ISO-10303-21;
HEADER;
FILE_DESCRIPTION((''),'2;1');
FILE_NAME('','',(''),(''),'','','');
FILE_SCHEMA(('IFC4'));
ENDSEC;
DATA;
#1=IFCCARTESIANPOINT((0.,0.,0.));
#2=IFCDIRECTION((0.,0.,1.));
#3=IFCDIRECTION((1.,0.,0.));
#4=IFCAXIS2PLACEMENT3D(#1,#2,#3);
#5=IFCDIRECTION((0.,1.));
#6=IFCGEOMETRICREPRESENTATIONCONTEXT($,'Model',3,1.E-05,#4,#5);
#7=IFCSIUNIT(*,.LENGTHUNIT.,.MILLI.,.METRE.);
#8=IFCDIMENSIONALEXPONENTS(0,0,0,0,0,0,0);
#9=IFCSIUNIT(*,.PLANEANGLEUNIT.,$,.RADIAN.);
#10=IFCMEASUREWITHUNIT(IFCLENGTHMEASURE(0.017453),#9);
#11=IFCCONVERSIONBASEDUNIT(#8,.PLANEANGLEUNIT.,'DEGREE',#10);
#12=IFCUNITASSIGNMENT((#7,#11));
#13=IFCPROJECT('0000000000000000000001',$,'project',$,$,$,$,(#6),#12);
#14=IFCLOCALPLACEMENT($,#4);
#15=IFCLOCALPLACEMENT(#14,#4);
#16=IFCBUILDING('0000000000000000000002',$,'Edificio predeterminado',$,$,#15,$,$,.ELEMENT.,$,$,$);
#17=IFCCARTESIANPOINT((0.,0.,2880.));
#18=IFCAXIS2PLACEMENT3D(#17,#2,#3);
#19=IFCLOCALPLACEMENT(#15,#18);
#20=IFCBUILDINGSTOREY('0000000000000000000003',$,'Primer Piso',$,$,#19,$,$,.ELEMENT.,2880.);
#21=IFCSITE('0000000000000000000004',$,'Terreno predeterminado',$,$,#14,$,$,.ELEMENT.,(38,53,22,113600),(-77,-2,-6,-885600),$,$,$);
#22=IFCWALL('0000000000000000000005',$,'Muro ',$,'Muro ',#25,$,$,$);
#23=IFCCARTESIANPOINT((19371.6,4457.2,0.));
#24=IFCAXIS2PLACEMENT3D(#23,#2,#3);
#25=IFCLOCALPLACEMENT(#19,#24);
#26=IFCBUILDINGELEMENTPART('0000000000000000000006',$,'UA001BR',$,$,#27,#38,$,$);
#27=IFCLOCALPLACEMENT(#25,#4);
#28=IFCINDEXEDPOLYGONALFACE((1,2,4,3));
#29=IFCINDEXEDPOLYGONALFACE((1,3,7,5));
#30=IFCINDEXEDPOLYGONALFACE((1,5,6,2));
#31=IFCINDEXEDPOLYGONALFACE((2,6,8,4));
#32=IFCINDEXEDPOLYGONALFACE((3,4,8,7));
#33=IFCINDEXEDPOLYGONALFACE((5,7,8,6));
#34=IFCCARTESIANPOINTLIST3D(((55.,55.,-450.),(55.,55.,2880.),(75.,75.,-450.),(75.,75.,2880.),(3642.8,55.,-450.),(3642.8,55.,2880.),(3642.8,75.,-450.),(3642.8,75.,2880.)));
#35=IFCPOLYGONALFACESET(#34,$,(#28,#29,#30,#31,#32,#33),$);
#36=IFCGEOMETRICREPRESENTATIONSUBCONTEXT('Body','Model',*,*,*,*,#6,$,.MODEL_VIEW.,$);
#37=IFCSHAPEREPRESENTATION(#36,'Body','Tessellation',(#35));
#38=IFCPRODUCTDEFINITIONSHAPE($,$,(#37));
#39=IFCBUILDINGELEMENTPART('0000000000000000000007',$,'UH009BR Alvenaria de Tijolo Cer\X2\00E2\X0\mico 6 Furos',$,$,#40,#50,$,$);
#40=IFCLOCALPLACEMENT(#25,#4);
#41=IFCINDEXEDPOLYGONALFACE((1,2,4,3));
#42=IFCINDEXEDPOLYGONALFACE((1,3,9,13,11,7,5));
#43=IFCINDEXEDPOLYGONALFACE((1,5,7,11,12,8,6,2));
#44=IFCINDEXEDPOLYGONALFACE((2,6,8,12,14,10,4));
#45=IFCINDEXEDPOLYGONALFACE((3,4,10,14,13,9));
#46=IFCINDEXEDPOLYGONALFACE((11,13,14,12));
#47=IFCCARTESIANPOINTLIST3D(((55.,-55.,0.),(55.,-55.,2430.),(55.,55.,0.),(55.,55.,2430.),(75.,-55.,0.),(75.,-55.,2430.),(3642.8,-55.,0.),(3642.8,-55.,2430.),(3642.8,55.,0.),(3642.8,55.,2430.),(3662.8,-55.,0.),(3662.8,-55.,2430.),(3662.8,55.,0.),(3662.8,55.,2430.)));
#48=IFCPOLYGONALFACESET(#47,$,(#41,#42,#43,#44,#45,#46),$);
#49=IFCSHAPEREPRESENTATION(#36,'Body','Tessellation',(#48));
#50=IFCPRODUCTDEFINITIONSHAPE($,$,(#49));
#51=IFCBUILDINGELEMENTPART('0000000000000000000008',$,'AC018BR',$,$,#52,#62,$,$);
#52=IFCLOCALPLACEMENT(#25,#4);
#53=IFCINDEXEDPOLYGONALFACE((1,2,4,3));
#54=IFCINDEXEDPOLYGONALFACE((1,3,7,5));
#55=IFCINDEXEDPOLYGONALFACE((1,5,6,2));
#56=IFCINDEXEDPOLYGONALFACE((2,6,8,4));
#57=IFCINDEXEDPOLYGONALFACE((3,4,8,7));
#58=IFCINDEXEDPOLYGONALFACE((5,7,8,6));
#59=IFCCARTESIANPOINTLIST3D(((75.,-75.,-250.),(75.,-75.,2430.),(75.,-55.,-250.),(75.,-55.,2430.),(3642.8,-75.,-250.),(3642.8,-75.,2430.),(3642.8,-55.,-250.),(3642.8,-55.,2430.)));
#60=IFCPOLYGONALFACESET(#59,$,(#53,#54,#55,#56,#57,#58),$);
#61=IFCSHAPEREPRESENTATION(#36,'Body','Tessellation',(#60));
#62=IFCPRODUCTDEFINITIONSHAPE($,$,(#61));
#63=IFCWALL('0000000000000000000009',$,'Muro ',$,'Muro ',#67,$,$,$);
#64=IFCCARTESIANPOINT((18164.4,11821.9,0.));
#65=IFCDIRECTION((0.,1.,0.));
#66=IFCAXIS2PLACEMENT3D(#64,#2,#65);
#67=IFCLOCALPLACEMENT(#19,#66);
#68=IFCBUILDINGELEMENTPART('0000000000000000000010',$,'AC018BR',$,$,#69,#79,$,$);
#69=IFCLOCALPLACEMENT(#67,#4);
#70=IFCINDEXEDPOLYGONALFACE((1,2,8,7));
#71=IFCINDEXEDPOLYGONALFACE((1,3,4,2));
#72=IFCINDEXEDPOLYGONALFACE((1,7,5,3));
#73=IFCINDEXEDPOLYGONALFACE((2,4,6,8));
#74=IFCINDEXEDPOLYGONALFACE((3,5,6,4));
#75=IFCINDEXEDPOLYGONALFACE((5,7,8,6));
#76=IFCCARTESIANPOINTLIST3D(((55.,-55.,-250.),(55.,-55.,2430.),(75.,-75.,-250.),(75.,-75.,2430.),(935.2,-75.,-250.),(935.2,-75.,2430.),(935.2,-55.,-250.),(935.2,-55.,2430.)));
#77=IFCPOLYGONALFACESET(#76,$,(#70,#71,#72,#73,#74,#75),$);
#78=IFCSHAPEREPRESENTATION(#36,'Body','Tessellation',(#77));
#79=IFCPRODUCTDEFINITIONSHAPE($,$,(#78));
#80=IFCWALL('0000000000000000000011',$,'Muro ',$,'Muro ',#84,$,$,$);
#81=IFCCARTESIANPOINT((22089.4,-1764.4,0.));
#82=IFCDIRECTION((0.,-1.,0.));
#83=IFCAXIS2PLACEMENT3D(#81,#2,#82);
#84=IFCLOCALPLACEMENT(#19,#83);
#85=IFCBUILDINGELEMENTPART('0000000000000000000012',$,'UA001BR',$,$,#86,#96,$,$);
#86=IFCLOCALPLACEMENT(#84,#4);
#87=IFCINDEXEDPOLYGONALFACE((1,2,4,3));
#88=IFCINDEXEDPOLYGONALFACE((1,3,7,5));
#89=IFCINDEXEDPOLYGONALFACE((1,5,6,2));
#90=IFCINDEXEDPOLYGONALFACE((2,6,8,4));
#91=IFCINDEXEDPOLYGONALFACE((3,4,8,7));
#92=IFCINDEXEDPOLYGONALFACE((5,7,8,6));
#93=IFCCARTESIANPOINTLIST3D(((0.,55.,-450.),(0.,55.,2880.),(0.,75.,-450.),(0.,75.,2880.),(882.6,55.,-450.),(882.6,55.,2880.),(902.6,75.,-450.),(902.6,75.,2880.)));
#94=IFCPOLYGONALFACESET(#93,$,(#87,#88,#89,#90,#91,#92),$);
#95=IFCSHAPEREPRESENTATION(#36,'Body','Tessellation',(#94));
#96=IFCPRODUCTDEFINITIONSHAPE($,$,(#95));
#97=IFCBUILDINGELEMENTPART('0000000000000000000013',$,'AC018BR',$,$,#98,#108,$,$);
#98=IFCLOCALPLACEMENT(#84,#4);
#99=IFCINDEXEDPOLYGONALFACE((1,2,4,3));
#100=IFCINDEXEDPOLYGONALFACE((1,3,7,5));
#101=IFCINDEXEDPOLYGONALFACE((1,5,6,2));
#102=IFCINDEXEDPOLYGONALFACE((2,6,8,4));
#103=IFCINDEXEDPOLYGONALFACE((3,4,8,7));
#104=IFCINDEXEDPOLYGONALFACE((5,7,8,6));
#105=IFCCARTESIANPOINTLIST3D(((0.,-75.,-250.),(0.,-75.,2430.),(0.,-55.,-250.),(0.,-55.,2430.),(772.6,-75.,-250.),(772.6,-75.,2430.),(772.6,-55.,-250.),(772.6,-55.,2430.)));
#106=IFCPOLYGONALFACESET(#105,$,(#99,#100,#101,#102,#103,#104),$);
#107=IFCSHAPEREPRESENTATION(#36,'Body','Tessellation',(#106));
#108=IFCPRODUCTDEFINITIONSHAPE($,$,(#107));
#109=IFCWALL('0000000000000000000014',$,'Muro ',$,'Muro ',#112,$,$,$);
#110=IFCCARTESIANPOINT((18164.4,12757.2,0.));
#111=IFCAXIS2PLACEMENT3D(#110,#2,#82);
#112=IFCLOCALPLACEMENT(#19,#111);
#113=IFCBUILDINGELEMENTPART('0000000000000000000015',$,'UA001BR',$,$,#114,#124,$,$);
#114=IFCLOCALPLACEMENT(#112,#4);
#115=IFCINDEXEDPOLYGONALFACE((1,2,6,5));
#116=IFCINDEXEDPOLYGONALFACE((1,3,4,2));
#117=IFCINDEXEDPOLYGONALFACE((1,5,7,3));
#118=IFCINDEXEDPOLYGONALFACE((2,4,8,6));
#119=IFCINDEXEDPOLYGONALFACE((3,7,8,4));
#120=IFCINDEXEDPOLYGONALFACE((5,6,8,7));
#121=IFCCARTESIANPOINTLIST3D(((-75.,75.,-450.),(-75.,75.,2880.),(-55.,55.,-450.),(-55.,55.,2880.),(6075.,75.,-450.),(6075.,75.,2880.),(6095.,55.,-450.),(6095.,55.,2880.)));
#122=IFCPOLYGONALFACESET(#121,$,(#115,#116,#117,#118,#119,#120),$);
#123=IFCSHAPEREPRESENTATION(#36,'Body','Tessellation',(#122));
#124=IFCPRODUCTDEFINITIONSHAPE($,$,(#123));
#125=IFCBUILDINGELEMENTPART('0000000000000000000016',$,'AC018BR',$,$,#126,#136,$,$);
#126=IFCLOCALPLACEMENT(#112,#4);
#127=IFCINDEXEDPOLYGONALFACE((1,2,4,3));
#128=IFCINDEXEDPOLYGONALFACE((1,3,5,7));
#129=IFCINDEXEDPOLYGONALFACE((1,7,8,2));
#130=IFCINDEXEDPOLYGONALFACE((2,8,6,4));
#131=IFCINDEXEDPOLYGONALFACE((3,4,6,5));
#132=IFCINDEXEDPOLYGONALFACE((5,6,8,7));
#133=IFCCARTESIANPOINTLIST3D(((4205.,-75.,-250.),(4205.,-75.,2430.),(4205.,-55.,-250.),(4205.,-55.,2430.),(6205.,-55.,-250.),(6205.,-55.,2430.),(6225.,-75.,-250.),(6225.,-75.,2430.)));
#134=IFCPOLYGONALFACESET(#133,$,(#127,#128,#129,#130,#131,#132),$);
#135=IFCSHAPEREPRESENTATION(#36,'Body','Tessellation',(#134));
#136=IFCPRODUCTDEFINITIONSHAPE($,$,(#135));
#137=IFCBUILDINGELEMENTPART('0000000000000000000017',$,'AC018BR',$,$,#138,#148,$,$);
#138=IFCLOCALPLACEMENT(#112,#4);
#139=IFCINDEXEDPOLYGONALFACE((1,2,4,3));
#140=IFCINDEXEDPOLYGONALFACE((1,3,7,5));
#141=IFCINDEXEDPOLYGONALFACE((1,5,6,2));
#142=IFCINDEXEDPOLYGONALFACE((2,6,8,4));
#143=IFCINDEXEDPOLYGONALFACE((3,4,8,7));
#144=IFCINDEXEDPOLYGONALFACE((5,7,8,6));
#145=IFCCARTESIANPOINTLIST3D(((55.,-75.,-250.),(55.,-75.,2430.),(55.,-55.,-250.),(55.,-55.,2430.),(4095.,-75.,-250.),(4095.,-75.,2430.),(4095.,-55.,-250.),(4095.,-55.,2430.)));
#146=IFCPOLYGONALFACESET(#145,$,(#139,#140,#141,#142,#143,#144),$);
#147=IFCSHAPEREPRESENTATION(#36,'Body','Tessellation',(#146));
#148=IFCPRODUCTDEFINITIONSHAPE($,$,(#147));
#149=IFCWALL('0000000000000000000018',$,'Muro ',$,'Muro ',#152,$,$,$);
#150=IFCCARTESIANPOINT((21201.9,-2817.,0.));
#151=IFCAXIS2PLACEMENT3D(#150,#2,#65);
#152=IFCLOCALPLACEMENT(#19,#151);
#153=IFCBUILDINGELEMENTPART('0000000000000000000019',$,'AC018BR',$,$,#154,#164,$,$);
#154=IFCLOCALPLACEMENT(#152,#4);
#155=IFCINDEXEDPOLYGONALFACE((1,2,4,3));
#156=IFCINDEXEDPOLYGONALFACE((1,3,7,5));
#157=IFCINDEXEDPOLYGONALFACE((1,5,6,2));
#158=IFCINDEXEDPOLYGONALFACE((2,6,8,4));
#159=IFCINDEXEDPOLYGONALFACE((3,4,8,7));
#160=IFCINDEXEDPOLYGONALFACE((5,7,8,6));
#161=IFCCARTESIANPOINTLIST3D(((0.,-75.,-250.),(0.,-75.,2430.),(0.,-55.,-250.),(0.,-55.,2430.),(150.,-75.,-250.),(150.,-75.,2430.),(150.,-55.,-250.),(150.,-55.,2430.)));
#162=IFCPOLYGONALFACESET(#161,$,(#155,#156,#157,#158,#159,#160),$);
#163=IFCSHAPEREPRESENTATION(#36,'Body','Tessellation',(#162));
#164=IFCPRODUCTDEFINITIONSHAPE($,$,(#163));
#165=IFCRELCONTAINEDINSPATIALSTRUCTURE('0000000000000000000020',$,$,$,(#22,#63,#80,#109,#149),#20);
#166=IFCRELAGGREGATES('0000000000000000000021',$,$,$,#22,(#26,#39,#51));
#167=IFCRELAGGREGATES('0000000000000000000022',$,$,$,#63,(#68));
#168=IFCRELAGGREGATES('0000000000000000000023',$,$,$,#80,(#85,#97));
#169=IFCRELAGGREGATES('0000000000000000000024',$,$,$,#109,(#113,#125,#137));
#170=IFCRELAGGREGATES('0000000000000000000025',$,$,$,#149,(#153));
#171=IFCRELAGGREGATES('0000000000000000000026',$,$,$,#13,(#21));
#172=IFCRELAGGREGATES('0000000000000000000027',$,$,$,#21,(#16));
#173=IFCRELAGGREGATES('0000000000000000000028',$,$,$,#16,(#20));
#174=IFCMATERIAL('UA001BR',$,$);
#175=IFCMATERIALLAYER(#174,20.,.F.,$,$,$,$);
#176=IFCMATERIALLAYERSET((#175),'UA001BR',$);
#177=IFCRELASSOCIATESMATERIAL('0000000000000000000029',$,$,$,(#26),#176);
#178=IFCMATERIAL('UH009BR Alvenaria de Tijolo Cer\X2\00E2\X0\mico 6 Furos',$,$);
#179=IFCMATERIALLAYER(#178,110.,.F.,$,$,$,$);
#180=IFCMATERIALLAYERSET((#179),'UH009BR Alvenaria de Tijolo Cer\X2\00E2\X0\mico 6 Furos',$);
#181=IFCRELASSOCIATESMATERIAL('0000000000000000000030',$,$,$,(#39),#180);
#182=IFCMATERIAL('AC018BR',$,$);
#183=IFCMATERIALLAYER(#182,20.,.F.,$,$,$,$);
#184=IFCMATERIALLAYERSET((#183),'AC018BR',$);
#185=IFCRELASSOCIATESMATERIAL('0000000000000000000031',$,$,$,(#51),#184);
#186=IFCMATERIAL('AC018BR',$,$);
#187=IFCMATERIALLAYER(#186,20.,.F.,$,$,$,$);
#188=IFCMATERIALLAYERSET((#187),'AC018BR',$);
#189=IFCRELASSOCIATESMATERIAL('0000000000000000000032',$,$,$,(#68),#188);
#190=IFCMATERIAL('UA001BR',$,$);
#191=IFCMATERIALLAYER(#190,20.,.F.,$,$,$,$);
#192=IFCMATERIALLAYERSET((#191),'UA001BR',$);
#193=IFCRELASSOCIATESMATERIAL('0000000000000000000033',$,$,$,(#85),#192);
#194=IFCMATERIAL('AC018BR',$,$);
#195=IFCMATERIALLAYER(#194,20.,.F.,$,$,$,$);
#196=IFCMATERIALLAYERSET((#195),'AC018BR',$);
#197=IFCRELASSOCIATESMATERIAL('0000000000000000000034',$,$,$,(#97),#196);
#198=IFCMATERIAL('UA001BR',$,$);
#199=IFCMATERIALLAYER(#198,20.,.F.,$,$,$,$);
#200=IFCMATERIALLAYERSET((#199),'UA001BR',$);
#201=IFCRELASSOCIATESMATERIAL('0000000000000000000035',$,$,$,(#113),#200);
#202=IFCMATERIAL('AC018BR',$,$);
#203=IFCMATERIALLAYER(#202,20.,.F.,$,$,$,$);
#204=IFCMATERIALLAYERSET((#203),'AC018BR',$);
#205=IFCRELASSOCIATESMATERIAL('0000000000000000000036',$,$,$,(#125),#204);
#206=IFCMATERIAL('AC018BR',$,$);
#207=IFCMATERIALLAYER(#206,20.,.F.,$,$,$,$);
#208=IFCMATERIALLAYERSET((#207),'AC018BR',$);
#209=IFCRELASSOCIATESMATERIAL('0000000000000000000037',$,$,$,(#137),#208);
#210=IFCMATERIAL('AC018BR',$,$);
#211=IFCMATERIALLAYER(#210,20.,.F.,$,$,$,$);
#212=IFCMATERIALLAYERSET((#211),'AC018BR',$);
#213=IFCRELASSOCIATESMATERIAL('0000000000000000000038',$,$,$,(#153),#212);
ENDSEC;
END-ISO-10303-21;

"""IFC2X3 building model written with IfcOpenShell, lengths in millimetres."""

from ifc_helpers import new_model, entity, si_unit, converted_unit, direction, frame, origin_with_axes, place, context, subcontext, project, spatial, polyline, outline, extrude, clip, bounded_halfspace, material, layer, layer_set, layer_usage, element, aggregate, save


model = new_model("IFC2X3")

# Units and contexts
model_context = context("Model", 3, precision=1e-05, world=origin_with_axes(), true_north=direction((0.0, 1.0)))
body_context = subcontext(model_context, "Body", "Model", "MODEL_VIEW")
ifc_project = project(units=[si_unit("LENGTHUNIT", "METRE", prefix="MILLI"), converted_unit("PLANEANGLEUNIT", "DEGREE", entity("IfcLengthMeasure", 0.017453), si_unit("PLANEANGLEUNIT", "RADIAN"), dimensions=[0, 0, 0, 0, 0, 0, 0])], contexts=[model_context])

# Site, building, storey
site_placement = place(None, origin_with_axes())
site = spatial("IfcSite", under=ifc_project, at=site_placement, Name="Terreno predeterminado", CompositionType="ELEMENT", RefLatitude=(38, 53, 22, 113600), RefLongitude=(-77, -2, -6, -885600))
building_placement = place(site_placement, origin_with_axes())
building = spatial("IfcBuilding", under=site, at=building_placement, Name="Edificio predeterminado", CompositionType="ELEMENT")
storey_placement = place(building_placement, frame((0.0, 0.0, 2880.0), z_axis=(0.0, 0.0, 1.0), x_axis=(1.0, 0.0, 0.0)))
storey = spatial("IfcBuildingStorey", under=building, at=storey_placement, Name="Primer Piso", CompositionType="ELEMENT", Elevation=2880.0)

# Walls, building element parts
wall_1_placement = place(storey_placement, frame((19371.6, 4457.2, 0.0), z_axis=(0.0, 0.0, 1.0), x_axis=(1.0, 0.0, 0.0)))
wall_1 = element("IfcWall", 1, at=wall_1_placement, inside=storey, Name="Muro ", ObjectType="Muro ")
ifc_material_1 = material(Name="UA001BR")
ifc_layer_1 = layer(ifc_material_1, 20.0, ventilated=False)
ifc_layer_set_1 = layer_set([ifc_layer_1], Name="UA001BR")
ifc_layer_usage_1 = layer_usage(ifc_layer_set_1, "AXIS2", "NEGATIVE", -75.0)
building_element_part_1_placement = place(wall_1_placement, origin_with_axes())
building_element_part_1 = element("IfcBuildingElementPart", 2, at=building_element_part_1_placement, material=ifc_layer_usage_1, Name="UA001BR", context=body_context, shape_type="SweptSolid", body=[
    extrude(outline(polyline([(3642.8, 75.0), (3642.8, 55.0), (55.0, 55.0), (75.0, 75.0), (3642.8, 75.0)])), frame((0.0, 0.0, -450.0), z_axis=(0.0, 0.0, 1.0), x_axis=(1.0, 0.0, 0.0)), (0.0, 0.0, 1.0), 3330.0),
])
ifc_material_2 = material(Name="UH009BR Alvenaria de Tijolo Cerâmico 6 Furos")
ifc_layer_2 = layer(ifc_material_2, 110.0, ventilated=False)
ifc_layer_set_2 = layer_set([ifc_layer_2], Name="UH009BR Alvenaria de Tijolo Cerâmico 6 Furos")
ifc_layer_usage_2 = layer_usage(ifc_layer_set_2, "AXIS2", "NEGATIVE", -55.0)
building_element_part_2_placement = place(wall_1_placement, origin_with_axes())
building_element_part_2 = element("IfcBuildingElementPart", 3, at=building_element_part_2_placement, material=ifc_layer_usage_2, Name="UH009BR Alvenaria de Tijolo Cerâmico 6 Furos", context=body_context, shape_type="SweptSolid", body=[
    extrude(outline(polyline([(3662.8, 55.0), (3662.8, -55.0), (3642.8, -55.0), (75.0, -55.0), (55.0, -55.0), (55.0, 55.0), (3642.8, 55.0), (3662.8, 55.0)])), origin_with_axes(), (0.0, 0.0, 1.0), 2430.0),
])
ifc_material_3 = material(Name="AC018BR")
ifc_layer_3 = layer(ifc_material_3, 20.0, ventilated=False)
ifc_layer_set_3 = layer_set([ifc_layer_3], Name="AC018BR")
ifc_layer_usage_3 = layer_usage(ifc_layer_set_3, "AXIS2", "NEGATIVE", 55.0)
building_element_part_3_placement = place(wall_1_placement, origin_with_axes())
building_element_part_3 = element("IfcBuildingElementPart", 4, at=building_element_part_3_placement, material=ifc_layer_usage_3, Name="AC018BR", context=body_context, shape_type="SweptSolid", body=[
    extrude(outline(polyline([(3642.8, -55.0), (3642.8, -75.0), (75.0, -75.0), (75.0, -55.0), (3642.8, -55.0)])), frame((0.0, 0.0, -250.0), z_axis=(0.0, 0.0, 1.0), x_axis=(1.0, 0.0, 0.0)), (0.0, 0.0, 1.0), 2680.0),
])
aggregate(wall_1, [building_element_part_1, building_element_part_2, building_element_part_3])
wall_2_placement = place(storey_placement, frame((18164.4, 11821.9, 0.0), z_axis=(0.0, 0.0, 1.0), x_axis=(0.0, 1.0, 0.0)))
wall_2 = element("IfcWall", 5, at=wall_2_placement, inside=storey, Name="Muro ", ObjectType="Muro ")
ifc_material_4 = material(Name="AC018BR")
ifc_layer_4 = layer(ifc_material_4, 20.0, ventilated=False)
ifc_layer_set_4 = layer_set([ifc_layer_4], Name="AC018BR")
ifc_layer_usage_4 = layer_usage(ifc_layer_set_4, "AXIS2", "NEGATIVE", 55.0)
building_element_part_4_placement = place(wall_2_placement, origin_with_axes())
building_element_part_4 = element("IfcBuildingElementPart", 6, at=building_element_part_4_placement, material=ifc_layer_usage_4, Name="AC018BR", context=body_context, shape_type="SweptSolid", body=[
    extrude(outline(polyline([(935.2, -55.0), (935.2, -75.0), (75.0, -75.0), (55.0, -55.0), (935.2, -55.0)])), frame((0.0, 0.0, -250.0), z_axis=(0.0, 0.0, 1.0), x_axis=(1.0, 0.0, 0.0)), (0.0, 0.0, 1.0), 2680.0),
])
aggregate(wall_2, [building_element_part_4])
wall_3_placement = place(storey_placement, frame((22089.4, -1764.4, 0.0), z_axis=(0.0, 0.0, 1.0), x_axis=(0.0, -1.0, 0.0)))
wall_3 = element("IfcWall", 7, at=wall_3_placement, inside=storey, Name="Muro ", ObjectType="Muro ")
ifc_material_5 = material(Name="UA001BR")
ifc_layer_5 = layer(ifc_material_5, 20.0, ventilated=False)
ifc_layer_set_5 = layer_set([ifc_layer_5], Name="UA001BR")
ifc_layer_usage_5 = layer_usage(ifc_layer_set_5, "AXIS2", "NEGATIVE", -75.0)
building_element_part_5_placement = place(wall_3_placement, origin_with_axes())
building_element_part_5 = element("IfcBuildingElementPart", 8, at=building_element_part_5_placement, material=ifc_layer_usage_5, Name="UA001BR", context=body_context, shape_type="SweptSolid", body=[
    extrude(outline(polyline([(902.6, 75.0), (882.6, 55.0), (0.0, 55.0), (0.0, 75.0), (902.6, 75.0)])), frame((0.0, 0.0, -450.0), z_axis=(0.0, 0.0, 1.0), x_axis=(1.0, 0.0, 0.0)), (0.0, 0.0, 1.0), 3330.0),
])
ifc_material_6 = material(Name="AC018BR")
ifc_layer_6 = layer(ifc_material_6, 20.0, ventilated=False)
ifc_layer_set_6 = layer_set([ifc_layer_6], Name="AC018BR")
ifc_layer_usage_6 = layer_usage(ifc_layer_set_6, "AXIS2", "NEGATIVE", 55.0)
building_element_part_6_placement = place(wall_3_placement, origin_with_axes())
building_element_part_6 = element("IfcBuildingElementPart", 9, at=building_element_part_6_placement, material=ifc_layer_usage_6, Name="AC018BR", context=body_context, shape_type="SweptSolid", body=[
    extrude(outline(polyline([(772.6, -55.0), (772.6, -75.0), (0.0, -75.0), (0.0, -55.0), (772.6, -55.0)])), frame((0.0, 0.0, -250.0), z_axis=(0.0, 0.0, 1.0), x_axis=(1.0, 0.0, 0.0)), (0.0, 0.0, 1.0), 2680.0),
])
aggregate(wall_3, [building_element_part_5, building_element_part_6])
wall_4_placement = place(storey_placement, frame((18164.4, 12757.2, 0.0), z_axis=(0.0, 0.0, 1.0), x_axis=(0.0, -1.0, 0.0)))
wall_4 = element("IfcWall", 10, at=wall_4_placement, inside=storey, Name="Muro ", ObjectType="Muro ")
ifc_material_7 = material(Name="UA001BR")
ifc_layer_7 = layer(ifc_material_7, 20.0, ventilated=False)
ifc_layer_set_7 = layer_set([ifc_layer_7], Name="UA001BR")
ifc_layer_usage_7 = layer_usage(ifc_layer_set_7, "AXIS2", "NEGATIVE", -75.0)
building_element_part_7_placement = place(wall_4_placement, origin_with_axes())
building_element_part_7 = element("IfcBuildingElementPart", 11, at=building_element_part_7_placement, material=ifc_layer_usage_7, Name="UA001BR", context=body_context, shape_type="SweptSolid", body=[
    extrude(outline(polyline([(6075.0, 75.0), (6095.0, 55.0), (-55.0, 55.0), (-75.0, 75.0), (6075.0, 75.0)])), frame((0.0, 0.0, -450.0), z_axis=(0.0, 0.0, 1.0), x_axis=(1.0, 0.0, 0.0)), (0.0, 0.0, 1.0), 3330.0),
])
ifc_material_8 = material(Name="AC018BR")
ifc_layer_8 = layer(ifc_material_8, 20.0, ventilated=False)
ifc_layer_set_8 = layer_set([ifc_layer_8], Name="AC018BR")
ifc_layer_usage_8 = layer_usage(ifc_layer_set_8, "AXIS2", "NEGATIVE", 55.0)
building_element_part_8_placement = place(wall_4_placement, origin_with_axes())
building_element_part_8 = element("IfcBuildingElementPart", 12, at=building_element_part_8_placement, material=ifc_layer_usage_8, Name="AC018BR", context=body_context, shape_type="SweptSolid", body=[
    extrude(outline(polyline([(6205.0, -55.0), (6225.0, -75.0), (4205.0, -75.0), (4205.0, -55.0), (6205.0, -55.0)])), frame((0.0, 0.0, -250.0), z_axis=(0.0, 0.0, 1.0), x_axis=(1.0, 0.0, 0.0)), (0.0, 0.0, 1.0), 2680.0),
])
ifc_material_9 = material(Name="AC018BR")
ifc_layer_9 = layer(ifc_material_9, 20.0, ventilated=False)
ifc_layer_set_9 = layer_set([ifc_layer_9], Name="AC018BR")
ifc_layer_usage_9 = layer_usage(ifc_layer_set_9, "AXIS2", "NEGATIVE", 55.0)
building_element_part_9_placement = place(wall_4_placement, origin_with_axes())
building_element_part_9 = element("IfcBuildingElementPart", 13, at=building_element_part_9_placement, material=ifc_layer_usage_9, Name="AC018BR", context=body_context, shape_type="SweptSolid", body=[
    extrude(outline(polyline([(4095.0, -55.0), (4095.0, -75.0), (55.0, -75.0), (55.0, -55.0), (4095.0, -55.0)])), frame((0.0, 0.0, -250.0), z_axis=(0.0, 0.0, 1.0), x_axis=(1.0, 0.0, 0.0)), (0.0, 0.0, 1.0), 2680.0),
])
aggregate(wall_4, [building_element_part_7, building_element_part_8, building_element_part_9])
wall_5_placement = place(storey_placement, frame((21201.9, -2817.0, 0.0), z_axis=(0.0, 0.0, 1.0), x_axis=(0.0, 1.0, 0.0)))
wall_5 = element("IfcWall", 14, at=wall_5_placement, inside=storey, Name="Muro ", ObjectType="Muro ")
ifc_material_10 = material(Name="AC018BR")
ifc_layer_10 = layer(ifc_material_10, 20.0, ventilated=False)
ifc_layer_set_10 = layer_set([ifc_layer_10], Name="AC018BR")
ifc_layer_usage_10 = layer_usage(ifc_layer_set_10, "AXIS2", "NEGATIVE", 55.0)
building_element_part_10_placement = place(wall_5_placement, origin_with_axes())
building_element_part_10 = element("IfcBuildingElementPart", 15, at=building_element_part_10_placement, material=ifc_layer_usage_10, Name="AC018BR", context=body_context, shape_type="Clipping", body=[
    clip(clip(extrude(outline(polyline([(150.0, -55.0), (150.0, -75.0), (0.0, -75.0), (0.0, -55.0), (150.0, -55.0)])), frame((0.0, 0.0, -250.0), z_axis=(0.0, 0.0, 1.0), x_axis=(1.0, 0.0, 0.0)), (0.0, 0.0, 1.0), 2680.0), bounded_halfspace(frame((0.0, 0.0, -250.0), z_axis=(0.0, 0.0, 1.0), x_axis=(1.0, 0.0, 0.0)), True, origin_with_axes(), polyline([(-150.0, -150.0), (375.0, -150.0), (375.0, 150.0), (-150.0, 150.0), (-150.0, -150.0)]))), bounded_halfspace(frame((0.0, 0.0, 2430.0), z_axis=(0.0, 0.0, 1.0), x_axis=(1.0, 0.0, 0.0)), False, origin_with_axes(), polyline([(-150.0, -150.0), (375.0, -150.0), (375.0, 150.0), (-150.0, 150.0), (-150.0, -150.0)]))),
])
aggregate(wall_5, [building_element_part_10])

save(model, "model.ifc")
